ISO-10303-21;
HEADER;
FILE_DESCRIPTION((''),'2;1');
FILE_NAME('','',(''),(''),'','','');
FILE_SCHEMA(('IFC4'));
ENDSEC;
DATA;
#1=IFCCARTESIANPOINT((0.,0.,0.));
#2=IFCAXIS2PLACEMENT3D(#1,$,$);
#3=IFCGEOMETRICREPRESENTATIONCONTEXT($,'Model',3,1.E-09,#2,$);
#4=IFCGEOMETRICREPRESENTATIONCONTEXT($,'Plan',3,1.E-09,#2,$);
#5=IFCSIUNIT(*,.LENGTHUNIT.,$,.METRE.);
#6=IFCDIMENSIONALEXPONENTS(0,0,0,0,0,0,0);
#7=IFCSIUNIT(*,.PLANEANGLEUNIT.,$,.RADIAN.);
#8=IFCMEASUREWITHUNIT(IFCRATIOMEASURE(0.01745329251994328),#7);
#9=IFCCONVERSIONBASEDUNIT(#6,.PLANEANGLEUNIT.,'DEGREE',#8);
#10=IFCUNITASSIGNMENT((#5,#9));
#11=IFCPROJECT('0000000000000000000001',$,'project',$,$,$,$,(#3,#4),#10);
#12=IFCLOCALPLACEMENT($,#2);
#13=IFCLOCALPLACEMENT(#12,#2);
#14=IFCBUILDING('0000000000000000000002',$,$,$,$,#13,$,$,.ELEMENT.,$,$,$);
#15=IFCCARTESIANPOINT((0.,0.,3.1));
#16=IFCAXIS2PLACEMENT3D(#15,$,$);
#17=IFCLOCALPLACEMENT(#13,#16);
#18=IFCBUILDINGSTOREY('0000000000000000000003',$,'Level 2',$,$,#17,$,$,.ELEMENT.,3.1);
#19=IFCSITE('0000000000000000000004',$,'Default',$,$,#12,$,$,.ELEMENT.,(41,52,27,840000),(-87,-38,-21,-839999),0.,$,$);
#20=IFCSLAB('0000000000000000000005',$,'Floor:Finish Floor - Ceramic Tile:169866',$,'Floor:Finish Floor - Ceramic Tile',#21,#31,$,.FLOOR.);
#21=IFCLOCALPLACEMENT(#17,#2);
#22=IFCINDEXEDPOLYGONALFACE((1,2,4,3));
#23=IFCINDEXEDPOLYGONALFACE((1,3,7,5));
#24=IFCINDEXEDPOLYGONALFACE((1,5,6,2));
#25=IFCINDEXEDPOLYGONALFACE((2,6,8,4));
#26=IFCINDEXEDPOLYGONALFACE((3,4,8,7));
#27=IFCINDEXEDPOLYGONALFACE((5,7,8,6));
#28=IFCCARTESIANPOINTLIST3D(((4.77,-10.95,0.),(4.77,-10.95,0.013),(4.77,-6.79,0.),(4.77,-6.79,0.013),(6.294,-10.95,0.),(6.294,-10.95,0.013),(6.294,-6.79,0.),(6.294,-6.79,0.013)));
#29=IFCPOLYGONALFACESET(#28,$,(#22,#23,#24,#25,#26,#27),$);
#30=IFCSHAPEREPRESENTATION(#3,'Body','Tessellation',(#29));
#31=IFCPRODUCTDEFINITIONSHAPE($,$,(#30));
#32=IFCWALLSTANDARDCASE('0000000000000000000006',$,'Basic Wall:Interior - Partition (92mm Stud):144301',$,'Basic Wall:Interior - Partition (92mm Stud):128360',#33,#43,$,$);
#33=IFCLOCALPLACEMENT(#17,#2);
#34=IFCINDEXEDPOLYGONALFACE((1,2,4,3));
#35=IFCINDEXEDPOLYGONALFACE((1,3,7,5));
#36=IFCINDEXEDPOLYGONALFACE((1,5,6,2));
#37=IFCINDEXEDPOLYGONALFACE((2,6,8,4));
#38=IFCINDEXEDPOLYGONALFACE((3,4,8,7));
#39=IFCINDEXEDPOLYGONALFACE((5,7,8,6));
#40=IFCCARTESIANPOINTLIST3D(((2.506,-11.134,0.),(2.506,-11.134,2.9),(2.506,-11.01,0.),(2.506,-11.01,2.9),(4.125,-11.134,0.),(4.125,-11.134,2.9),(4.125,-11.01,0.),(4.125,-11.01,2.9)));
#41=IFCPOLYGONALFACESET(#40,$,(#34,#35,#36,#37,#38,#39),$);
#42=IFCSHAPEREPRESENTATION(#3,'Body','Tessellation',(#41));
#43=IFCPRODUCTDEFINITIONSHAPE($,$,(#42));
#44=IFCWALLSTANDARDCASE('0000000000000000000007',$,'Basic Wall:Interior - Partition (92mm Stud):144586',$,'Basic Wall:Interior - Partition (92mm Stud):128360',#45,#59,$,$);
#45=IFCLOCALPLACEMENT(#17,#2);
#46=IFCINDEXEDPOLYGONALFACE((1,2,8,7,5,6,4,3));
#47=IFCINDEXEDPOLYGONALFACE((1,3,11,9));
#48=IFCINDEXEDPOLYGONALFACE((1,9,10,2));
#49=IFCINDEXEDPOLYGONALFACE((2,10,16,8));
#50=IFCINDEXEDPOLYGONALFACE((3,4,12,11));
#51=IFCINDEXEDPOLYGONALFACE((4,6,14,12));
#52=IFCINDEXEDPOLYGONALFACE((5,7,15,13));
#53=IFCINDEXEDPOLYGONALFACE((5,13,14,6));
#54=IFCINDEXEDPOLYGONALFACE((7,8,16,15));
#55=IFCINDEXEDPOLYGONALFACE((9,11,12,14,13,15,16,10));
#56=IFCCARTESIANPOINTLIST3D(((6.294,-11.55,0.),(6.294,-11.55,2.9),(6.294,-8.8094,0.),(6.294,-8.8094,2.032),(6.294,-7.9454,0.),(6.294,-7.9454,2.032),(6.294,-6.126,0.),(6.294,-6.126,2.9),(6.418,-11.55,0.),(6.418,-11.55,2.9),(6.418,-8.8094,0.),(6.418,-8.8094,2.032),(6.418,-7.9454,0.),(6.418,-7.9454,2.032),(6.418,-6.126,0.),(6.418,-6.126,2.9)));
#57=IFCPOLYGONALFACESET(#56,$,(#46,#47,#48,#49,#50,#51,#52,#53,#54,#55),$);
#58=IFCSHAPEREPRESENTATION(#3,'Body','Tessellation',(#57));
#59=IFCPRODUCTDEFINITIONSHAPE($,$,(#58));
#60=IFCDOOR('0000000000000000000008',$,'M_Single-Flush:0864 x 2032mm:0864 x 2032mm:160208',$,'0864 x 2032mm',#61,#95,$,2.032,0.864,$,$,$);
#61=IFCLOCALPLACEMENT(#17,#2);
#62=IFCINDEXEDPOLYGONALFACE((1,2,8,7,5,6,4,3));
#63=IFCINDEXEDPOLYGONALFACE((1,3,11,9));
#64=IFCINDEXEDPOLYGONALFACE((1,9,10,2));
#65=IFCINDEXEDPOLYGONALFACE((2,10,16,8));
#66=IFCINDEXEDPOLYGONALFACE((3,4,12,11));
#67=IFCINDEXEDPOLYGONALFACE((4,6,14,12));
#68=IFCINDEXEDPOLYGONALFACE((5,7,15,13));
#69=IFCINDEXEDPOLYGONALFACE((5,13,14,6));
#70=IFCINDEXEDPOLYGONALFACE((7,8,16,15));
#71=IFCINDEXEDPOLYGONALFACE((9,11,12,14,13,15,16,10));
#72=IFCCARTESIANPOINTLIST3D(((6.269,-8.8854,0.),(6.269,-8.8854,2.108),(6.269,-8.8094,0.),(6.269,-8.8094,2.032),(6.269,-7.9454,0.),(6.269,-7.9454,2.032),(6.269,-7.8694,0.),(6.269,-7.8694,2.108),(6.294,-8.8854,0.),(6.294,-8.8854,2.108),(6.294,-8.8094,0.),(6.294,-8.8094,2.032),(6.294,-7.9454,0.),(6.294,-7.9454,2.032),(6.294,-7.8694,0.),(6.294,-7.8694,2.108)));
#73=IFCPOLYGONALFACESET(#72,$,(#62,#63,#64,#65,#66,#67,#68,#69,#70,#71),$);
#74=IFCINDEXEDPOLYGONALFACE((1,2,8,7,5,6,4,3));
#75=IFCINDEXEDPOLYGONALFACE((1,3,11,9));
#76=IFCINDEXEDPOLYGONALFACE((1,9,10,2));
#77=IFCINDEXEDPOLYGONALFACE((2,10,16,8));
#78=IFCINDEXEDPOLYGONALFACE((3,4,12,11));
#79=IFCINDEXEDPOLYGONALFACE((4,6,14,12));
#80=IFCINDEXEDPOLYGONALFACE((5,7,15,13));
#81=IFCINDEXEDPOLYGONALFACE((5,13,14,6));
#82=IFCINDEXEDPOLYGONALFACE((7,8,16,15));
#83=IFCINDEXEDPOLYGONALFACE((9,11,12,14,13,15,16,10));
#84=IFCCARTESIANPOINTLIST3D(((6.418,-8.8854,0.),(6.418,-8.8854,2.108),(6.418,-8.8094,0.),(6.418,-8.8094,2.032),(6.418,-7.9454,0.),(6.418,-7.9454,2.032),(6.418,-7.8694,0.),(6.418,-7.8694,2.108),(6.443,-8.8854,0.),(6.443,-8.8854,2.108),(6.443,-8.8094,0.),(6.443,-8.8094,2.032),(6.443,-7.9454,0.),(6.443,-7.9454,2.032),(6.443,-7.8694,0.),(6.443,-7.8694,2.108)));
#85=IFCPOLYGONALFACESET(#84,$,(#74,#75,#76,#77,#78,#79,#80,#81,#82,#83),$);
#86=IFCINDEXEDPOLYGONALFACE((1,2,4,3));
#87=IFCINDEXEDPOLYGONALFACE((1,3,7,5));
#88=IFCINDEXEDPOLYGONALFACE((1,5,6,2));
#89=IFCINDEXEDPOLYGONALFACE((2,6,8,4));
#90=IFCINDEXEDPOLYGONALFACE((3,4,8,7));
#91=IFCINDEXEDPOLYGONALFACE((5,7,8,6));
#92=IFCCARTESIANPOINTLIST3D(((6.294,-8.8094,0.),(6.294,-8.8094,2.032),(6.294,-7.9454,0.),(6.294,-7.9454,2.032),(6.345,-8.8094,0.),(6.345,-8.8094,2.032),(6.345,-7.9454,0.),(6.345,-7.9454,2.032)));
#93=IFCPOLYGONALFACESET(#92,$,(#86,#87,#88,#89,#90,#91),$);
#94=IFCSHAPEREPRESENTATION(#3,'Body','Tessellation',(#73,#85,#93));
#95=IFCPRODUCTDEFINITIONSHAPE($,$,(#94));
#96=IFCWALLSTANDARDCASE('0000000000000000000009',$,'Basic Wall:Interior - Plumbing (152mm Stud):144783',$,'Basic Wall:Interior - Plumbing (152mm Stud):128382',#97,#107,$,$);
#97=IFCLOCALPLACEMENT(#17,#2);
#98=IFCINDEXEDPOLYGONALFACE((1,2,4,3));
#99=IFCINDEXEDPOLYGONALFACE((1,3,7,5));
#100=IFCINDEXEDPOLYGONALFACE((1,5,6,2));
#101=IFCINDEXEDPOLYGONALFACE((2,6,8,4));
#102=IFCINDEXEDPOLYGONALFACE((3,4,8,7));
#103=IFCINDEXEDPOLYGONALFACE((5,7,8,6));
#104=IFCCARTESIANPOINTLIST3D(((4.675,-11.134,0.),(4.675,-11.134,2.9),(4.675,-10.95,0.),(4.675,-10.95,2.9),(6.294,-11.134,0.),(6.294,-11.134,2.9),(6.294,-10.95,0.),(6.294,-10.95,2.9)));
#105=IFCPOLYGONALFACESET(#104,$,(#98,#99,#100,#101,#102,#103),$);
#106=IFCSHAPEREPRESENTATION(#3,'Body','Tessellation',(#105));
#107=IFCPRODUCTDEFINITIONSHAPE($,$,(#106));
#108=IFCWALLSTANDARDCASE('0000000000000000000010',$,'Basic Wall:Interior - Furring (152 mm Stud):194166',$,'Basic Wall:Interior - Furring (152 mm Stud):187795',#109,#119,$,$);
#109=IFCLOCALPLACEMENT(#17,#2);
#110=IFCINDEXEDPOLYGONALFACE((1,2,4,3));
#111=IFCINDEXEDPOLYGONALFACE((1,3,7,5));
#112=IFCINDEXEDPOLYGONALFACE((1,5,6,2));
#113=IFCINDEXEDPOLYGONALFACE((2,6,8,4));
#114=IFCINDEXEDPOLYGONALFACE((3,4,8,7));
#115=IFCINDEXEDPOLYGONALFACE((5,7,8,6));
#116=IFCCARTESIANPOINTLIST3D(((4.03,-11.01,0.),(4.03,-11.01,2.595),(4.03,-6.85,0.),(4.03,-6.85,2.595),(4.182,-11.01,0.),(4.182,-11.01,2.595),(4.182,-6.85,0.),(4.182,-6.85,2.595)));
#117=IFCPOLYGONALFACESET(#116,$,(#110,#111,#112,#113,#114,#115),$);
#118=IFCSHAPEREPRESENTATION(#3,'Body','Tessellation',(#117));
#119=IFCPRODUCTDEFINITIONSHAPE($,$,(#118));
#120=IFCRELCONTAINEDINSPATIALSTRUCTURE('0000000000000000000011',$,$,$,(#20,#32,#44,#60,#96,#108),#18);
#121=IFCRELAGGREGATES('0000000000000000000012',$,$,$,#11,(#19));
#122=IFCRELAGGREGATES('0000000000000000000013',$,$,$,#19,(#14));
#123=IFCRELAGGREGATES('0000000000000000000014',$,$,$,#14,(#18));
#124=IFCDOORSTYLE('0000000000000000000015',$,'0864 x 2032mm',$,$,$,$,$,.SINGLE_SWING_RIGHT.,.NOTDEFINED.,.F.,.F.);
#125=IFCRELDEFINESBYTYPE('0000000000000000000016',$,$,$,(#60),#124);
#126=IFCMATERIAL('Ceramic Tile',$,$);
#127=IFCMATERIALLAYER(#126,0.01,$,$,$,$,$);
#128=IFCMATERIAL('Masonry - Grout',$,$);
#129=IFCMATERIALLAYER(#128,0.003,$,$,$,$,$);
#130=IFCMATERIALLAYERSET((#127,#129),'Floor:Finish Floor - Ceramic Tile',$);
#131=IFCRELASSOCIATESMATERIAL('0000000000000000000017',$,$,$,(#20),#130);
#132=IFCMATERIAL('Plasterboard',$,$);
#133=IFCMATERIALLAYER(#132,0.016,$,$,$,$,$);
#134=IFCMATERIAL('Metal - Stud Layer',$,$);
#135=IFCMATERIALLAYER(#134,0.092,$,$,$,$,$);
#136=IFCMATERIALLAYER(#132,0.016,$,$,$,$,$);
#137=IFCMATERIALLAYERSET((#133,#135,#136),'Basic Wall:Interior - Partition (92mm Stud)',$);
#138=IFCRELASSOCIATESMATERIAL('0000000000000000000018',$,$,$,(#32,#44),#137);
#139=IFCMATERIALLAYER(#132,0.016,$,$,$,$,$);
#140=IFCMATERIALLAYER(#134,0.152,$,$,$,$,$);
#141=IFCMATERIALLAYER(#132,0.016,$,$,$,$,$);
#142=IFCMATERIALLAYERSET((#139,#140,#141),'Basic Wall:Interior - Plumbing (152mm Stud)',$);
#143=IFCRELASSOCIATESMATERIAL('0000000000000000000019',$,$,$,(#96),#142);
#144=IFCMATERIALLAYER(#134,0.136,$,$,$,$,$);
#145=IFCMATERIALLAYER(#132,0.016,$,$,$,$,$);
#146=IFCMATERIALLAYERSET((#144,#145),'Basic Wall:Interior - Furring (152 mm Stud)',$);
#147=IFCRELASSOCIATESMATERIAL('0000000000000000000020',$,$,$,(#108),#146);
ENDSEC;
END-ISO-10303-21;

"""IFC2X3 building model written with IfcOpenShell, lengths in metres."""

from ifc_helpers import new_model, entity, si_unit, converted_unit, frame, frame_2d, origin, origin_2d_with_axis, place, context, project, spatial, polyline, rectangle, outline, extrude, source, transform, mapped, material, layer, layer_set, layer_usage, type_object, type_shapes, element, fill, save


model = new_model("IFC2X3")

# Units and contexts
model_context = context("Model", 3, precision=1e-09, world=origin())
plan_context = context("Plan", 3, precision=1e-09, world=origin())
ifc_project = project(units=[si_unit("LENGTHUNIT", "METRE"), converted_unit("PLANEANGLEUNIT", "DEGREE", entity("IfcRatioMeasure", 0.01745329251994328), si_unit("PLANEANGLEUNIT", "RADIAN"), dimensions=[0, 0, 0, 0, 0, 0, 0])], contexts=[model_context, plan_context])

# Site, building, storey
site_placement = place(None, origin())
site = spatial("IfcSite", under=ifc_project, at=site_placement, Name="Default", CompositionType="ELEMENT", RefLatitude=(41, 52, 27, 840000), RefLongitude=(-87, -38, -21, -839999), RefElevation=0.0)
building_placement = place(site_placement, origin())
building = spatial("IfcBuilding", under=site, at=building_placement, CompositionType="ELEMENT")
storey_placement = place(building_placement, frame((0.0, 0.0, 3.1)))
storey = spatial("IfcBuildingStorey", under=building, at=storey_placement, Name="Level 2", CompositionType="ELEMENT", Elevation=3.1)

# Slab
ifc_material_1 = material(Name="Ceramic Tile")
ifc_layer_1 = layer(ifc_material_1, 0.01)
ifc_material_2 = material(Name="Masonry - Grout")
ifc_layer_2 = layer(ifc_material_2, 0.003)
ifc_layer_set_1 = layer_set([ifc_layer_1, ifc_layer_2], Name="Floor:Finish Floor - Ceramic Tile")
ifc_layer_usage_1 = layer_usage(ifc_layer_set_1, "AXIS3", "POSITIVE", 0.0)
slab_placement = place(storey_placement, frame((4.77, -10.95, 0.0)))
element("IfcSlab", 1, at=slab_placement, inside=storey, material=ifc_layer_usage_1, Name="Floor:Finish Floor - Ceramic Tile:169866", ObjectType="Floor:Finish Floor - Ceramic Tile", PredefinedType="FLOOR", context=model_context, shape_type="SweptSolid", body=[
    extrude(rectangle(XDim=4.16, YDim=1.524, at=frame_2d((0.0, 0.0), x_axis=(0.0, -1.0))), frame((0.762, 2.08, 0.013), z_axis=(0.0, 0.0, -1.0), x_axis=(-1.0, 0.0, 0.0)), (0.0, 0.0, 1.0), 0.013),
])

# Wall
ifc_material_3 = material(Name="Plasterboard")
ifc_layer_3 = layer(ifc_material_3, 0.016)
ifc_material_4 = material(Name="Metal - Stud Layer")
ifc_layer_4 = layer(ifc_material_4, 0.092)
ifc_layer_5 = layer(ifc_material_3, 0.016)
ifc_layer_set_2 = layer_set([ifc_layer_3, ifc_layer_4, ifc_layer_5], Name="Basic Wall:Interior - Partition (92mm Stud)")
ifc_layer_usage_2 = layer_usage(ifc_layer_set_2, "AXIS2", "NEGATIVE", 0.062)
wall_1_placement = place(storey_placement, frame((4.125, -11.072, 0.0), z_axis=(0.0, 0.0, 1.0), x_axis=(-1.0, 0.0, 0.0)))
element("IfcWallStandardCase", 2, at=wall_1_placement, inside=storey, material=ifc_layer_usage_2, Name="Basic Wall:Interior - Partition (92mm Stud):144301", ObjectType="Basic Wall:Interior - Partition (92mm Stud):128360", context=model_context, shape_type="SweptSolid", body=[
    extrude(rectangle(XDim=1.619, YDim=0.124, at=frame_2d((0.8095, 0.0), x_axis=(-1.0, 0.0))), origin(), (0.0, 0.0, 1.0), 2.9),
])

# Wall, opening, door
ifc_layer_usage_3 = layer_usage(ifc_layer_set_2, "AXIS2", "NEGATIVE", 0.062)
wall_2_placement = place(storey_placement, frame((6.356, -11.55, 0.0), z_axis=(0.0, 0.0, 1.0), x_axis=(0.0, 1.0, 0.0)))
wall_2 = element("IfcWallStandardCase", 3, at=wall_2_placement, inside=storey, material=ifc_layer_usage_3, Name="Basic Wall:Interior - Partition (92mm Stud):144586", ObjectType="Basic Wall:Interior - Partition (92mm Stud):128360", context=model_context, shape_type="SweptSolid", body=[
    extrude(rectangle(XDim=5.424, YDim=0.124, at=frame_2d((2.712, 0.0), x_axis=(-1.0, 0.0))), origin(), (0.0, 0.0, 1.0), 2.9),
])
opening_placement = place(wall_2_placement, frame((2.7406, -0.062, 0.0)))
opening = element("IfcOpeningElement", 4, at=opening_placement, cuts=wall_2, ObjectType="Opening", context=model_context, shape_type="SweptSolid", body=[
    extrude(rectangle(XDim=0.864, YDim=2.032, at=frame_2d((1.016, 0.432), x_axis=(0.0, 1.0))), frame((0.0, 0.0, 0.0), z_axis=(0.0, 1.0, 0.0), x_axis=(0.0, 0.0, 1.0)), (0.0, 0.0, 1.0), 0.124),
])
door_style = type_object("IfcDoorStyle", Name="0864 x 2032mm", ConstructionType="NOTDEFINED", OperationType="SINGLE_SWING_RIGHT", ParameterTakesPrecedence=False, Sizeable=False)
shared_shape = source(origin(), model_context, "Body", "SweptSolid", [
    extrude(outline(polyline([(-0.508, -1.073), (0.508, -1.073), (0.508, 1.035), (0.432, 1.035), (0.432, -0.997), (-0.432, -0.997), (-0.432, 1.035), (-0.508, 1.035), (-0.508, -1.073)])), frame((0.432, 0.124, 1.035), z_axis=(0.0, 1.0, 0.0), x_axis=(1.0, 0.0, 0.0)), (0.0, 0.0, 1.0), 0.025),
    extrude(outline(polyline([(-1.073, -0.508), (1.035, -0.508), (1.035, -0.432), (-0.997, -0.432), (-0.997, 0.432), (1.035, 0.432), (1.035, 0.508), (-1.073, 0.508), (-1.073, -0.508)])), frame((0.432, -0.025, 1.035), z_axis=(0.0, 1.0, 0.0), x_axis=(0.0, 0.0, -1.0)), (0.0, 0.0, 1.0), 0.025),
    extrude(rectangle(XDim=0.051, YDim=0.864, at=origin_2d_with_axis()), frame((0.432, 0.0985, 0.0), z_axis=(0.0, 0.0, 1.0), x_axis=(0.0, 1.0, 0.0)), (0.0, 0.0, 1.0), 2.032),
])
type_shapes(door_style, [shared_shape])
door_placement = place(opening_placement, origin())
door = element("IfcDoor", 5, at=door_placement, inside=storey, type_object=door_style, Name="M_Single-Flush:0864 x 2032mm:0864 x 2032mm:160208", ObjectType="0864 x 2032mm", OverallHeight=2.032, OverallWidth=0.864, context=model_context, shape_type="MappedRepresentation", body=[
    mapped(shared_shape, transform((0.0, 0.0, 0.0), scale=1.0)),
])
fill(opening, door)

# Walls
ifc_layer_6 = layer(ifc_material_3, 0.016)
ifc_layer_7 = layer(ifc_material_4, 0.152)
ifc_layer_8 = layer(ifc_material_3, 0.016)
ifc_layer_set_3 = layer_set([ifc_layer_6, ifc_layer_7, ifc_layer_8], Name="Basic Wall:Interior - Plumbing (152mm Stud)")
ifc_layer_usage_4 = layer_usage(ifc_layer_set_3, "AXIS2", "NEGATIVE", 0.092)
wall_3_placement = place(storey_placement, frame((6.294, -11.042, 0.0), z_axis=(0.0, 0.0, 1.0), x_axis=(-1.0, 0.0, 0.0)))
element("IfcWallStandardCase", 6, at=wall_3_placement, inside=storey, material=ifc_layer_usage_4, Name="Basic Wall:Interior - Plumbing (152mm Stud):144783", ObjectType="Basic Wall:Interior - Plumbing (152mm Stud):128382", context=model_context, shape_type="SweptSolid", body=[
    extrude(rectangle(XDim=1.619, YDim=0.184, at=frame_2d((0.8095, 0.0), x_axis=(-1.0, 0.0))), origin(), (0.0, 0.0, 1.0), 2.9),
])
ifc_layer_9 = layer(ifc_material_4, 0.136)
ifc_layer_10 = layer(ifc_material_3, 0.016)
ifc_layer_set_4 = layer_set([ifc_layer_9, ifc_layer_10], Name="Basic Wall:Interior - Furring (152 mm Stud)")
ifc_layer_usage_5 = layer_usage(ifc_layer_set_4, "AXIS2", "POSITIVE", -0.076)
wall_4_placement = place(storey_placement, frame((4.106, -11.01, 0.0), z_axis=(0.0, 0.0, 1.0), x_axis=(0.0, 1.0, 0.0)))
element("IfcWallStandardCase", 7, at=wall_4_placement, inside=storey, material=ifc_layer_usage_5, Name="Basic Wall:Interior - Furring (152 mm Stud):194166", ObjectType="Basic Wall:Interior - Furring (152 mm Stud):187795", context=model_context, shape_type="SweptSolid", body=[
    extrude(rectangle(XDim=4.16, YDim=0.152, at=frame_2d((2.08, 0.0), x_axis=(-1.0, 0.0))), origin(), (0.0, 0.0, 1.0), 2.595),
])

save(model, "model.ifc")
